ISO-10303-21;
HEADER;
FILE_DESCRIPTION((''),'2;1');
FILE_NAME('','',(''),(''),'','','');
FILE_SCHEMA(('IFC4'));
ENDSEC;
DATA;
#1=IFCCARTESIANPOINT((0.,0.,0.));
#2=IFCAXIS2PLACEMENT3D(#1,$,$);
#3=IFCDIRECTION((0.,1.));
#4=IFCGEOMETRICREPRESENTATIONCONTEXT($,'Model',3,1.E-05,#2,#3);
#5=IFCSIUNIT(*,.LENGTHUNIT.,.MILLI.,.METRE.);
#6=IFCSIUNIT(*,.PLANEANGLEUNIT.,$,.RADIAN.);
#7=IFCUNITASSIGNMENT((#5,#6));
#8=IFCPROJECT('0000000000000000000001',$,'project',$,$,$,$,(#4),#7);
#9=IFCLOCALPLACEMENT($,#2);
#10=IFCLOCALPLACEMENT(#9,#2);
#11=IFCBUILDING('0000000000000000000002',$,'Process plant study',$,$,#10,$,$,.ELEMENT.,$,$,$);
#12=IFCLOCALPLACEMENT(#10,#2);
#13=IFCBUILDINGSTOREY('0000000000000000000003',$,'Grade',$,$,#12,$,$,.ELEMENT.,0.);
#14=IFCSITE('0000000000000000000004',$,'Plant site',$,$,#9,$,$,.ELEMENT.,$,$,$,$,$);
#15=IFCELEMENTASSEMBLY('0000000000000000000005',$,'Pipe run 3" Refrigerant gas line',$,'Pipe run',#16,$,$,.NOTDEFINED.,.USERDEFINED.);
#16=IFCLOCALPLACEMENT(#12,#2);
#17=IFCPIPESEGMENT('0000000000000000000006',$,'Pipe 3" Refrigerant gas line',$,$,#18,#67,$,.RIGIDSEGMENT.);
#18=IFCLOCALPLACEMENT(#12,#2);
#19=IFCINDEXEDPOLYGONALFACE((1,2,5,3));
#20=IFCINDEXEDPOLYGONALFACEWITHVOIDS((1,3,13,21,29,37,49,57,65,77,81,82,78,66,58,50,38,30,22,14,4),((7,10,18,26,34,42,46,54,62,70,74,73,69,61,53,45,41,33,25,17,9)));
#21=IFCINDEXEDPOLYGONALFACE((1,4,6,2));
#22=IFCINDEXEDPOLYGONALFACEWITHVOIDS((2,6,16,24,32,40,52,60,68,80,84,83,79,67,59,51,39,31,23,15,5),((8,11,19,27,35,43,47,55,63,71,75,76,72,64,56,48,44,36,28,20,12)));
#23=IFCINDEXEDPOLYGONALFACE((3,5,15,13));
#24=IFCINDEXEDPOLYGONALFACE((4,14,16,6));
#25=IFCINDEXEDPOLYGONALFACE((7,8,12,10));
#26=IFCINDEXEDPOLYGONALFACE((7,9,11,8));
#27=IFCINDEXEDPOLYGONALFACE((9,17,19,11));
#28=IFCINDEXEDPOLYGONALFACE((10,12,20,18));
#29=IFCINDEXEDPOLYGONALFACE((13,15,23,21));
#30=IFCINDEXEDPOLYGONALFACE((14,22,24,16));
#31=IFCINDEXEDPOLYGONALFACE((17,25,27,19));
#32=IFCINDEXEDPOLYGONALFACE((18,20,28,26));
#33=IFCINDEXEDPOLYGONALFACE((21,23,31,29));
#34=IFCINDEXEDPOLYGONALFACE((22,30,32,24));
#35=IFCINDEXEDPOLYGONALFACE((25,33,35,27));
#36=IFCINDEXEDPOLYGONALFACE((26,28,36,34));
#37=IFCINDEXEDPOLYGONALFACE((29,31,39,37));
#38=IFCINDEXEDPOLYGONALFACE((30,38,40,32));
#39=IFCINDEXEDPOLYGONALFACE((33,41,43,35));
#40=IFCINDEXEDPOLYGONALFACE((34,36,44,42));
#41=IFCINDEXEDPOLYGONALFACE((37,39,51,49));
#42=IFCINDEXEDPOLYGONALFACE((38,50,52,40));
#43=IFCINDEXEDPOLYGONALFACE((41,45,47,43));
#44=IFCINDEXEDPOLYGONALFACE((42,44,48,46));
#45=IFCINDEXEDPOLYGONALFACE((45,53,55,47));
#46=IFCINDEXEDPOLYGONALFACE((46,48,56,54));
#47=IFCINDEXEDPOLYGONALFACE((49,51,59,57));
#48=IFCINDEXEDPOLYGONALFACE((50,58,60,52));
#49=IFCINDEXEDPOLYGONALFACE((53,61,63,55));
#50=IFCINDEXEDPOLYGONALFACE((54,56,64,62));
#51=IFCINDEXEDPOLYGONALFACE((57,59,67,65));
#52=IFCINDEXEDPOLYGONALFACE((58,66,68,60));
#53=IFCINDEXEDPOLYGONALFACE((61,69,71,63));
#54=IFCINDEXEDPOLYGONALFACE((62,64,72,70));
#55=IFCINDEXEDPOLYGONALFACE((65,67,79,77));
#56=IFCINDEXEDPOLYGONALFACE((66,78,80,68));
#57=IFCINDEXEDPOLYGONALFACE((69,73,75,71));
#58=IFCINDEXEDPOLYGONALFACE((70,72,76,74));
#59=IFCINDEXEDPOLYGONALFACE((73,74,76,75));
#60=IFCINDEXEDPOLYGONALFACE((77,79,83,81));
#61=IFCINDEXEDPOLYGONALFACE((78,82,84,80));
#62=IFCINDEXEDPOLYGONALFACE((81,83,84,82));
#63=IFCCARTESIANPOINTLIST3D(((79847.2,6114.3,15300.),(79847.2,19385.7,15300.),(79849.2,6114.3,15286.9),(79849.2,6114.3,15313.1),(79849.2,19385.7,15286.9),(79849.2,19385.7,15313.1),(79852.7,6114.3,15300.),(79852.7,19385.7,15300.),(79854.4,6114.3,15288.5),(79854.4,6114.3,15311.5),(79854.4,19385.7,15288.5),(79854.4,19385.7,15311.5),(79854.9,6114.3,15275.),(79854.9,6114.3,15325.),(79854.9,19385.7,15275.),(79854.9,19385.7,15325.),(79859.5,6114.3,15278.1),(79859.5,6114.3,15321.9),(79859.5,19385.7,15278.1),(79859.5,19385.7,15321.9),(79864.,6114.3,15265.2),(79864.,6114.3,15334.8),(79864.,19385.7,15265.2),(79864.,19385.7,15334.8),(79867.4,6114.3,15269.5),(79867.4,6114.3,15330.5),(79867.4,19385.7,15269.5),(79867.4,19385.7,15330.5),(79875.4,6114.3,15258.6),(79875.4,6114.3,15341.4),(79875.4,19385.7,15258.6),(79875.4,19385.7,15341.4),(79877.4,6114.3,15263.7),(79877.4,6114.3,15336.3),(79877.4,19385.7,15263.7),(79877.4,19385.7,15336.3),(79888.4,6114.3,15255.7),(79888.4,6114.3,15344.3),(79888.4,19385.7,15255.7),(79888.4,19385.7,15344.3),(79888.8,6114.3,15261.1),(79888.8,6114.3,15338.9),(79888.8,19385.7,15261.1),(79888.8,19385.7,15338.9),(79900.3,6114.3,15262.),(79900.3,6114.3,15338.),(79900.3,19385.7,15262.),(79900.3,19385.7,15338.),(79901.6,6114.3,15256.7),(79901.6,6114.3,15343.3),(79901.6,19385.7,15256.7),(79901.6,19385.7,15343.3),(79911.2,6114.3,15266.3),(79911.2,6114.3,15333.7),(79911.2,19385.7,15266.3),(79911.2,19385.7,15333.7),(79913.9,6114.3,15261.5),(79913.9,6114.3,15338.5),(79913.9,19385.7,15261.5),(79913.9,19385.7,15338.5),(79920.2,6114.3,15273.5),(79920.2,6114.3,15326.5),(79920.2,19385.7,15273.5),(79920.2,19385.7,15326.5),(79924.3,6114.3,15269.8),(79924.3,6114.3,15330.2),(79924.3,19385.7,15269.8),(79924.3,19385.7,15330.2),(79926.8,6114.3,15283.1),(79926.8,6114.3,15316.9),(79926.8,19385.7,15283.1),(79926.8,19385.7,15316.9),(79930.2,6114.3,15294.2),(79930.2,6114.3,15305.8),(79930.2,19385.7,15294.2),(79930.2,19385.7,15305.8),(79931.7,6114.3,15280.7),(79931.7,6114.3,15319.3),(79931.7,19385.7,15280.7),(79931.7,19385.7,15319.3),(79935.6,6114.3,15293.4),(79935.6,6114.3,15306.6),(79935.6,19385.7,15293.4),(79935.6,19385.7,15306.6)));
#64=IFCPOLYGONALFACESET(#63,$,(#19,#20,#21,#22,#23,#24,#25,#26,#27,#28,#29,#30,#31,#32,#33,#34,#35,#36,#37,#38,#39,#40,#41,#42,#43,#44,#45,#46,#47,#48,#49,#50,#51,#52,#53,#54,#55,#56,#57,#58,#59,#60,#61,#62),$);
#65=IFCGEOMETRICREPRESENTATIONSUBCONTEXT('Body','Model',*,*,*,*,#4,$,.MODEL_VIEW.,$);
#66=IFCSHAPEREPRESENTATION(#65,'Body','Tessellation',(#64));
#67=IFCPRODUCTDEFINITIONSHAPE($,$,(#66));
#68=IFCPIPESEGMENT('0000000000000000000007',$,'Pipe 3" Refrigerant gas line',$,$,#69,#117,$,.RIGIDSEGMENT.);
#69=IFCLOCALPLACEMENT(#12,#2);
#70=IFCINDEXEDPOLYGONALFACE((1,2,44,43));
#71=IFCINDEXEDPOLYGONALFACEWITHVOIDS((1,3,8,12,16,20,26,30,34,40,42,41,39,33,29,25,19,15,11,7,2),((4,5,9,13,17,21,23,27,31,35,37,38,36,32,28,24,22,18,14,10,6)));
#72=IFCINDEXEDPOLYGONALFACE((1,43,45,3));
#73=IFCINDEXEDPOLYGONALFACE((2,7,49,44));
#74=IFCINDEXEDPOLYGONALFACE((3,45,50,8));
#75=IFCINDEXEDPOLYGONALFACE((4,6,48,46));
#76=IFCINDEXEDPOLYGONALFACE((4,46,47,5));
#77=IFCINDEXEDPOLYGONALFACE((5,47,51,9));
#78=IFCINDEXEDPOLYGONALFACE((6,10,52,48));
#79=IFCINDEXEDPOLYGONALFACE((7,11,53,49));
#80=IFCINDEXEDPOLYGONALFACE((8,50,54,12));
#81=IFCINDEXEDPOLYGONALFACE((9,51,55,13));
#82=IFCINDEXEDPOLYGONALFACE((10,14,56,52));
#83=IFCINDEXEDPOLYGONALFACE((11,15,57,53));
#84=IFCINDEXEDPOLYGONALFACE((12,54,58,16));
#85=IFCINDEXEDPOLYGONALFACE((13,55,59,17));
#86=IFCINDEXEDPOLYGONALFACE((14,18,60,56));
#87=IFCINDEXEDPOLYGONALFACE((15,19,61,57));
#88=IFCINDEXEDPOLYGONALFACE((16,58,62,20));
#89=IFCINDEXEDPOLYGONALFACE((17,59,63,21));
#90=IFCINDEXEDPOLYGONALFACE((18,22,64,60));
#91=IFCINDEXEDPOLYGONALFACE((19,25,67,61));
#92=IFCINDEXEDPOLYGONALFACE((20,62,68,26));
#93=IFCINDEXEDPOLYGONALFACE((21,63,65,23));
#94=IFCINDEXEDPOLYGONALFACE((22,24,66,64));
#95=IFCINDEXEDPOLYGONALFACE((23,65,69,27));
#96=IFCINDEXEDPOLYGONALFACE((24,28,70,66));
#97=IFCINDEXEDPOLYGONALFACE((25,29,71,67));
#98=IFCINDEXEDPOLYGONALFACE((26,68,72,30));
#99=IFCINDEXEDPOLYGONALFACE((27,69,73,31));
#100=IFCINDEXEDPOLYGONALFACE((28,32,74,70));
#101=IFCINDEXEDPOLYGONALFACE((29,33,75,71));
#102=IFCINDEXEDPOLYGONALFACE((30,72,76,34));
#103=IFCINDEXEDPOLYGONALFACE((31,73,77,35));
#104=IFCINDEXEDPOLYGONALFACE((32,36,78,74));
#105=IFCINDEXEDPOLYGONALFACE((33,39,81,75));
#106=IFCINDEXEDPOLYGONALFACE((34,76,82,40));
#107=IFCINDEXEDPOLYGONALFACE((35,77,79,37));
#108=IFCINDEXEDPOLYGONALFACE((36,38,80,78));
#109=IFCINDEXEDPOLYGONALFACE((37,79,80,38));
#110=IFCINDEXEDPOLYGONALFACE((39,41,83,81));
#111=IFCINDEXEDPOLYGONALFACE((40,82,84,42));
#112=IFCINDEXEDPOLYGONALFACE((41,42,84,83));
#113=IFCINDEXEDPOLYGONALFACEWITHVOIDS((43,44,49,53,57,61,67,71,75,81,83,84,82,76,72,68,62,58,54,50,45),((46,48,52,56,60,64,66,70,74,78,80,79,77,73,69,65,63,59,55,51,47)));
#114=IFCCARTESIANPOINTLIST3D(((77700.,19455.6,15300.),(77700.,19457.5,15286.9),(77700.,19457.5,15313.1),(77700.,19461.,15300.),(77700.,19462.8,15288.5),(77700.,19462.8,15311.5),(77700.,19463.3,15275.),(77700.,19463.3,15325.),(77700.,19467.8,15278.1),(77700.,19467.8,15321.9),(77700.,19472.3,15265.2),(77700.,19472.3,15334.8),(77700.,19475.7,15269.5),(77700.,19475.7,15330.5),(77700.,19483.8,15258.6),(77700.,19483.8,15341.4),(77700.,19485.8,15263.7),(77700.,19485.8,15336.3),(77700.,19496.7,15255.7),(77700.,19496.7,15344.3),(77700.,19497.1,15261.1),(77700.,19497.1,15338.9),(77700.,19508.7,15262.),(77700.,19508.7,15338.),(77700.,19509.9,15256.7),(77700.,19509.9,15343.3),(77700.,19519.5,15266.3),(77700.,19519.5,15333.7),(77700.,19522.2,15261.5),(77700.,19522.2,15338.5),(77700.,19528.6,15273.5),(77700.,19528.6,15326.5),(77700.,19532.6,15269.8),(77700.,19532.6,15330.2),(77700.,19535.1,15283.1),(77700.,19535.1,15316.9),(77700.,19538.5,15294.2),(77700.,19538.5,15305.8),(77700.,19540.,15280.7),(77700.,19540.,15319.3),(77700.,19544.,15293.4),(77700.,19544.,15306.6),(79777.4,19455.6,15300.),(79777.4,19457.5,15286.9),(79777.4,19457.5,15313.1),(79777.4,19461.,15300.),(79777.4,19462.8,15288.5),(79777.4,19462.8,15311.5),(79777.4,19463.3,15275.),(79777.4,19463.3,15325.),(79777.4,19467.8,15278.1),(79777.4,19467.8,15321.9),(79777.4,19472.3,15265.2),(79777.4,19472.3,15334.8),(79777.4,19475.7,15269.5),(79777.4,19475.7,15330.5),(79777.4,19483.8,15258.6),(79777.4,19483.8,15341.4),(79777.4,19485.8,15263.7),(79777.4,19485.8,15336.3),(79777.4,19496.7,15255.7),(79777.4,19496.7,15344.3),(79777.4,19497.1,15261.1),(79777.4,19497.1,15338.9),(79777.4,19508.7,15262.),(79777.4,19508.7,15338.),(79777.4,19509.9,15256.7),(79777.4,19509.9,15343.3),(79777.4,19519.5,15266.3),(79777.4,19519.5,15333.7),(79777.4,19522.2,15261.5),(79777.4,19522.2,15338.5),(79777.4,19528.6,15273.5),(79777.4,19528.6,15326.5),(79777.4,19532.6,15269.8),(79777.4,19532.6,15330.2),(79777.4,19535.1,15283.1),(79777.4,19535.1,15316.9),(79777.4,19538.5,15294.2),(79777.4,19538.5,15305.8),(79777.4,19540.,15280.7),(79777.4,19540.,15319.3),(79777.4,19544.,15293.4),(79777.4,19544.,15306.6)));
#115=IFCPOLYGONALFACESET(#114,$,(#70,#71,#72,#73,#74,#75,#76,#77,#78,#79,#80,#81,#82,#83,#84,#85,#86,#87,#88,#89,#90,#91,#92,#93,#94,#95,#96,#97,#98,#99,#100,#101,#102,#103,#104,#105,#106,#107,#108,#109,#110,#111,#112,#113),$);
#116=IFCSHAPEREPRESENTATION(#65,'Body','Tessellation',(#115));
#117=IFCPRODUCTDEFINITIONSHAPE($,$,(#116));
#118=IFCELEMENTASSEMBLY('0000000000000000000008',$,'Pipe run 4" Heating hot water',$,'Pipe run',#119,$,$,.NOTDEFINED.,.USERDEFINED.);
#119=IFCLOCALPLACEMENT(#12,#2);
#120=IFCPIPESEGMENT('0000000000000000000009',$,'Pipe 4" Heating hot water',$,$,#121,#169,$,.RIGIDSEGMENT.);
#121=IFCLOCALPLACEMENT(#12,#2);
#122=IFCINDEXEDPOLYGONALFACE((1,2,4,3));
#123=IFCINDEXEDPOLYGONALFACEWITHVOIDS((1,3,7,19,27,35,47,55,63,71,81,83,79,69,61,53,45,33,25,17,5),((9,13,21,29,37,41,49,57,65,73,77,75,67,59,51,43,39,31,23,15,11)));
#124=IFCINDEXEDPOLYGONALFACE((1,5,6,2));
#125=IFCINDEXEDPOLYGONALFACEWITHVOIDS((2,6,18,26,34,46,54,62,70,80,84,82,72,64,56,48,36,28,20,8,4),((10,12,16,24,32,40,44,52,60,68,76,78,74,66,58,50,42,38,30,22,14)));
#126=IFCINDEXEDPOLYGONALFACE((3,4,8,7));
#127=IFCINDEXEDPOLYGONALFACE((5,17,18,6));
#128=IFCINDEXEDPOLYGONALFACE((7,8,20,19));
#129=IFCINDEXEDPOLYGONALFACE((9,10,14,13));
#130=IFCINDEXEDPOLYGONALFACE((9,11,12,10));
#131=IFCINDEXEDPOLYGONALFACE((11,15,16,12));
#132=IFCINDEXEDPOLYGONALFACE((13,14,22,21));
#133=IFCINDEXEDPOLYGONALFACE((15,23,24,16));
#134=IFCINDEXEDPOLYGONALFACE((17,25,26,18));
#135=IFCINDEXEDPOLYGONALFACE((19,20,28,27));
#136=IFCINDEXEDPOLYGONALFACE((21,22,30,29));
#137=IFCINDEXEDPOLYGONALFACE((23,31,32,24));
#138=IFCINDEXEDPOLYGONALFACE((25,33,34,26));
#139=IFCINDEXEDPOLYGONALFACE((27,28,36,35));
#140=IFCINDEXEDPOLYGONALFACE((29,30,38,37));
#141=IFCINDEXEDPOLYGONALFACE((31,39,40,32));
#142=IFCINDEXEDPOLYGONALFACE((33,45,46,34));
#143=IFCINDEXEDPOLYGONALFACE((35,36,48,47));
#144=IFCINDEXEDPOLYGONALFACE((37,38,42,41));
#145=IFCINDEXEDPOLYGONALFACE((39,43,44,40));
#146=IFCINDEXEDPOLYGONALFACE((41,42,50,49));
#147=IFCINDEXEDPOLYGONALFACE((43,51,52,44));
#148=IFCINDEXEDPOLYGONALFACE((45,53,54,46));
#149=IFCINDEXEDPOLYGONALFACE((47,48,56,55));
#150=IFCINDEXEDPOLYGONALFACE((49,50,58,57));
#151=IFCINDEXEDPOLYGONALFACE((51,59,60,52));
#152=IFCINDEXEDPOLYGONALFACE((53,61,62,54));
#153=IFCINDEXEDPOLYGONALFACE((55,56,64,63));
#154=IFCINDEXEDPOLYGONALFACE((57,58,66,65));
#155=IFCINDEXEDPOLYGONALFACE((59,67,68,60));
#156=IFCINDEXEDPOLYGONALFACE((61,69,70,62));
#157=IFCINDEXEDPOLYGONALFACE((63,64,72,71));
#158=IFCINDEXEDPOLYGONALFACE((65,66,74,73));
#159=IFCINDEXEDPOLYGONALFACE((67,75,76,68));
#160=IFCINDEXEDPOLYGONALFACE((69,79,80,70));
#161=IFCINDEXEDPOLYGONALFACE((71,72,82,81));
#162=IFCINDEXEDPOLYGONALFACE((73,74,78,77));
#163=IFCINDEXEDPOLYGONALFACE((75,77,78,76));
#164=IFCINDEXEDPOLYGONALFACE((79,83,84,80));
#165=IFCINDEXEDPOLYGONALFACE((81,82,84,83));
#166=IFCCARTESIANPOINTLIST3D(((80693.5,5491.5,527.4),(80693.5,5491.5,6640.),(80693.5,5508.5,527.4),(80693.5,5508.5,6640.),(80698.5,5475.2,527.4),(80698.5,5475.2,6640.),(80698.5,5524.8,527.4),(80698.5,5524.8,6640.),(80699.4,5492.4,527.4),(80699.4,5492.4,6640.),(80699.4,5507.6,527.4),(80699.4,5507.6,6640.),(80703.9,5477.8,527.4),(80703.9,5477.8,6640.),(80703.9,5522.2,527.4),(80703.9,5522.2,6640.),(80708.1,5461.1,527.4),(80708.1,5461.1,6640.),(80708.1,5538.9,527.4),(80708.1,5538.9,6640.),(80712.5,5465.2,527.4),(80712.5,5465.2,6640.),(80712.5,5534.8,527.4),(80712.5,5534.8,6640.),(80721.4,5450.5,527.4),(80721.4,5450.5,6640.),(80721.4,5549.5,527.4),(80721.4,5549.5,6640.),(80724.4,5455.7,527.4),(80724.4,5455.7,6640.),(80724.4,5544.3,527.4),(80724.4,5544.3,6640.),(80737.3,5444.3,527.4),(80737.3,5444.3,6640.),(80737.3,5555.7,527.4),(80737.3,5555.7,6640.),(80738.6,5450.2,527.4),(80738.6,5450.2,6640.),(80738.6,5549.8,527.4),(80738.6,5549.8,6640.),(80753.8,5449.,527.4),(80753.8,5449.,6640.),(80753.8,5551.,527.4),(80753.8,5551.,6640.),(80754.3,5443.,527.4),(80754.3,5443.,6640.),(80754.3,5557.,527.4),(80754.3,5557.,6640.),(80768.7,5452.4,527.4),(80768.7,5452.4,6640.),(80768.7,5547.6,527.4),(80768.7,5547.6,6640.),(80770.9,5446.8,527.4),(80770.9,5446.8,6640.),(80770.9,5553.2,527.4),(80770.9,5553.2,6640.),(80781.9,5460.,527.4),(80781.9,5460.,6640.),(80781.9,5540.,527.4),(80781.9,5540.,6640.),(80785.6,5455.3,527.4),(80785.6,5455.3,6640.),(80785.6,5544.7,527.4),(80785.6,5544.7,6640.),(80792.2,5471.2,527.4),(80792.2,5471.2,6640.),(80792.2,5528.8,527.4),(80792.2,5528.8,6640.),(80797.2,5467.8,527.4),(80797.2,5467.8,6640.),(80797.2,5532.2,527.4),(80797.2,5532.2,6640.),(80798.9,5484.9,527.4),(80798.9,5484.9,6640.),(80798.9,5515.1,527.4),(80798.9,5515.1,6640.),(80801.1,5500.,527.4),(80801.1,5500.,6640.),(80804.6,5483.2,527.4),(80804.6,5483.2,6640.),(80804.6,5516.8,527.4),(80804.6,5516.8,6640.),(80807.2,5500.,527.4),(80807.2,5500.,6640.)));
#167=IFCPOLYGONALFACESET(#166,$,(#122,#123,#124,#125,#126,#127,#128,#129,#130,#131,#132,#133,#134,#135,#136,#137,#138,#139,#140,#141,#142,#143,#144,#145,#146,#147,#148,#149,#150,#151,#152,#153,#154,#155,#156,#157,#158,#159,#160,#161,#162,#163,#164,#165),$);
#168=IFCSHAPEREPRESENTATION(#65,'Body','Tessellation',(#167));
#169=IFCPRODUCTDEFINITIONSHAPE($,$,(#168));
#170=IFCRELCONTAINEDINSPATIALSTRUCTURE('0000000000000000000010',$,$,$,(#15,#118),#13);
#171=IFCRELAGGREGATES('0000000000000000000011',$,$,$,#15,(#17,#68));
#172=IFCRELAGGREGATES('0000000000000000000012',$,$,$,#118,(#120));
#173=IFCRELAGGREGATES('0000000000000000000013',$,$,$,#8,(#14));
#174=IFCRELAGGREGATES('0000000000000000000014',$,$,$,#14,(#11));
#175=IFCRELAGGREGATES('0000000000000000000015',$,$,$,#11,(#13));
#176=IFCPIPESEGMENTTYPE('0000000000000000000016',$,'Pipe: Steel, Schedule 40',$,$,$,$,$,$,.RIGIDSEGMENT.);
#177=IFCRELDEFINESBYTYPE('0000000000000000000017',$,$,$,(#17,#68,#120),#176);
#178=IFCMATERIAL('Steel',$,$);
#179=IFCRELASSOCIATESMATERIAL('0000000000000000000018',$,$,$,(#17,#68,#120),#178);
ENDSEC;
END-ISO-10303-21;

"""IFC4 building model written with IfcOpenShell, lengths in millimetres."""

from ifc_helpers import new_model, si_unit, direction, frame, origin, origin_with_axes, origin_2d, place, context, subcontext, project, spatial, hollow_circle, extrude, material, type_object, element, aggregate, save


model = new_model("IFC4")

# Units and contexts
model_context = context("Model", 3, precision=1e-05, world=origin(), true_north=direction((0.0, 1.0)))
body_context = subcontext(model_context, "Body", "Model", "MODEL_VIEW")
ifc_project = project(units=[si_unit("LENGTHUNIT", "METRE", prefix="MILLI"), si_unit("PLANEANGLEUNIT", "RADIAN")], contexts=[model_context])

# Site, building, storey
site_placement = place(None, origin())
site = spatial("IfcSite", under=ifc_project, at=site_placement, Name="Plant site", CompositionType="ELEMENT")
building_placement = place(site_placement, origin())
building = spatial("IfcBuilding", under=site, at=building_placement, Name="Process plant study", CompositionType="ELEMENT")
storey_placement = place(building_placement, origin())
storey = spatial("IfcBuildingStorey", under=building, at=storey_placement, Name="Grade", CompositionType="ELEMENT", Elevation=0.0)

# Element assemblies, pipe segments
assembly_1_placement = place(storey_placement, origin_with_axes())
assembly_1 = element("IfcElementAssembly", 1, at=assembly_1_placement, inside=storey, Name="Pipe run 3\" Refrigerant gas line", ObjectType="Pipe run", AssemblyPlace="NOTDEFINED", PredefinedType="USERDEFINED")
ifc_material = material(Name="Steel")
pipe_segment_type = type_object("IfcPipeSegmentType", Name="Pipe: Steel, Schedule 40", PredefinedType="RIGIDSEGMENT")
pipe_segment_1_placement = place(storey_placement, origin_with_axes())
pipe_segment_1 = element("IfcPipeSegment", 2, at=pipe_segment_1_placement, type_object=pipe_segment_type, material=ifc_material, Name="Pipe 3\" Refrigerant gas line", PredefinedType="RIGIDSEGMENT", context=body_context, shape_type="SweptSolid", body=[
    extrude(hollow_circle(Radius=44.5, WallThickness=5.5, at=origin_2d()), frame((79891.7, 6114.3, 15300.0), z_axis=(0.0, 1.0, 0.0), x_axis=(-1.0, 0.0, 0.0)), (0.0, 0.0, 1.0), 13271.4),
])
pipe_segment_2_placement = place(storey_placement, origin_with_axes())
pipe_segment_2 = element("IfcPipeSegment", 3, at=pipe_segment_2_placement, type_object=pipe_segment_type, material=ifc_material, Name="Pipe 3\" Refrigerant gas line", PredefinedType="RIGIDSEGMENT", context=body_context, shape_type="SweptSolid", body=[
    extrude(hollow_circle(Radius=44.5, WallThickness=5.5, at=origin_2d()), frame((79777.4, 19500.0, 15300.0), z_axis=(-1.0, 0.0, 0.0), x_axis=(0.0, -1.0, 0.0)), (0.0, 0.0, 1.0), 2077.4),
])
assembly_2_placement = place(storey_placement, origin_with_axes())
assembly_2 = element("IfcElementAssembly", 4, at=assembly_2_placement, inside=storey, Name="Pipe run 4\" Heating hot water", ObjectType="Pipe run", AssemblyPlace="NOTDEFINED", PredefinedType="USERDEFINED")
pipe_segment_3_placement = place(storey_placement, origin_with_axes())
pipe_segment_3 = element("IfcPipeSegment", 5, at=pipe_segment_3_placement, type_object=pipe_segment_type, material=ifc_material, Name="Pipe 4\" Heating hot water", PredefinedType="RIGIDSEGMENT", context=body_context, shape_type="SweptSolid", body=[
    extrude(hollow_circle(Radius=57.1, WallThickness=6.0, at=origin_2d()), frame((80750.0, 5500.0, 6640.0), z_axis=(0.0, 0.0, -1.0), x_axis=(1.0, 0.0, 0.0)), (0.0, 0.0, 1.0), 6112.6),
])

aggregate(assembly_1, [pipe_segment_1, pipe_segment_2])
aggregate(assembly_2, [pipe_segment_3])

save(model, "model.ifc")
